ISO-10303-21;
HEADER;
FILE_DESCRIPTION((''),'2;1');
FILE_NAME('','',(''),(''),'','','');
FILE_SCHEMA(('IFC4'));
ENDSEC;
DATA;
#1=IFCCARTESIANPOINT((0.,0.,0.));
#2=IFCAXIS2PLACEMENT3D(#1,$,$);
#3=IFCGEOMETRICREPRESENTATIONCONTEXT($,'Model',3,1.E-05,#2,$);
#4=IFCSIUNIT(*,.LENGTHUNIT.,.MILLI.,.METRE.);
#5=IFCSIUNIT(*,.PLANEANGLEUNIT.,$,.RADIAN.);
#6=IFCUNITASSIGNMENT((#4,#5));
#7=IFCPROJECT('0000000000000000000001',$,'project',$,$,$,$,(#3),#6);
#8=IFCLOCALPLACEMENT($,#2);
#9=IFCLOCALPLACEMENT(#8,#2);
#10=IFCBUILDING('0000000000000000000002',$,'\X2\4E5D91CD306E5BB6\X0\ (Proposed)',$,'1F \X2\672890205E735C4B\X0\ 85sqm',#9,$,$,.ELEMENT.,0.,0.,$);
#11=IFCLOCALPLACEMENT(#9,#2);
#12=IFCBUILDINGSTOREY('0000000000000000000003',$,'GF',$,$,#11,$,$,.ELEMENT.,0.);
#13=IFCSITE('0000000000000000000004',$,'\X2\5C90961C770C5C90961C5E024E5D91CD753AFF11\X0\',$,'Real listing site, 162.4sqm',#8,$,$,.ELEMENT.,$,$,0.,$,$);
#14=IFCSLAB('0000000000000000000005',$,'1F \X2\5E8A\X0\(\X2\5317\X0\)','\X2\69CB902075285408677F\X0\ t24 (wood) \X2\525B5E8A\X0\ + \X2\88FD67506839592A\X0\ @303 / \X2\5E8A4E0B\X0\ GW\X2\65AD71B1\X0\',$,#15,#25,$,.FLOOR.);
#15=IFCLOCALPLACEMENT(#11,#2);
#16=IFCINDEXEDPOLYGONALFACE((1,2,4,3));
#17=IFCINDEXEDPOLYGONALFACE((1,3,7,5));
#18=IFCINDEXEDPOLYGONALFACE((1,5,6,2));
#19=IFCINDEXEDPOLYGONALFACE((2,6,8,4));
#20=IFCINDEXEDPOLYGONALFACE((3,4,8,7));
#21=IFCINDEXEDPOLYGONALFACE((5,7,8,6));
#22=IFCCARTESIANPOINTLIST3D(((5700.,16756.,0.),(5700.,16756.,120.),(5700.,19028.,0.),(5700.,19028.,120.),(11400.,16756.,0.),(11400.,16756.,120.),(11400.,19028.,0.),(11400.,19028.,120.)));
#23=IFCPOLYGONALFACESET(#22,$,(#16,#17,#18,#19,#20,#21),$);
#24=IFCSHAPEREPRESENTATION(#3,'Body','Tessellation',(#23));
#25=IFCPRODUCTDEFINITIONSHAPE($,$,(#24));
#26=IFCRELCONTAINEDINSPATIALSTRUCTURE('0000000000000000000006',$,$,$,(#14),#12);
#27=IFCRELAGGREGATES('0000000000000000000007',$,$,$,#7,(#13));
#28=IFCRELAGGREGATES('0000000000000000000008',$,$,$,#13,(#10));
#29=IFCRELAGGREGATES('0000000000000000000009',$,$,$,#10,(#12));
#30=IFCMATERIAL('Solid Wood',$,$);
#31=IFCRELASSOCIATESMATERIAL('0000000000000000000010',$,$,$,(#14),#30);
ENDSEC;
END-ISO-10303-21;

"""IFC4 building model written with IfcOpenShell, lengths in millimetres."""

from ifc_helpers import new_model, si_unit, frame, frame_2d, origin, place, context, project, spatial, rectangle, extrude, material, element, save


model = new_model("IFC4")

# Units and contexts
model_context = context("Model", 3, precision=1e-05, world=origin())
ifc_project = project(units=[si_unit("LENGTHUNIT", "METRE", prefix="MILLI"), si_unit("PLANEANGLEUNIT", "RADIAN")], contexts=[model_context])

# Site, building, storey
site_placement = place(None, origin())
site = spatial("IfcSite", under=ifc_project, at=site_placement, Name="岐阜県岐阜市九重町１", ObjectType="Real listing site, 162.4sqm", CompositionType="ELEMENT", RefElevation=0.0)
building_placement = place(site_placement, origin())
building = spatial("IfcBuilding", under=site, at=building_placement, Name="九重の家 (Proposed)", ObjectType="1F 木造平屋 85sqm", CompositionType="ELEMENT", ElevationOfRefHeight=0.0, ElevationOfTerrain=0.0)
storey_placement = place(building_placement, origin())
storey = spatial("IfcBuildingStorey", under=building, at=storey_placement, Name="GF", CompositionType="ELEMENT", Elevation=0.0)

# Slab
ifc_material_1 = material(Name="Solid Wood")
slab_1_placement = place(storey_placement, frame((2850.0, 8378.0, 0.0)))
element("IfcSlab", 1, at=slab_1_placement, inside=storey, material=ifc_material_1, Name="1F 床(北)", Description="構造用合板 t24 (wood) 剛床 + 製材根太 @303 / 床下 GW断熱", PredefinedType="FLOOR", context=model_context, shape_type="SweptSolid", body=[
    extrude(rectangle(XDim=5700.0, YDim=2272.0, at=frame_2d((2850.0, 1136.0))), frame((2850.0, 8378.0, 0.0)), (0.0, 0.0, 1.0), 120.0),
])

save(model, "model.ifc")
